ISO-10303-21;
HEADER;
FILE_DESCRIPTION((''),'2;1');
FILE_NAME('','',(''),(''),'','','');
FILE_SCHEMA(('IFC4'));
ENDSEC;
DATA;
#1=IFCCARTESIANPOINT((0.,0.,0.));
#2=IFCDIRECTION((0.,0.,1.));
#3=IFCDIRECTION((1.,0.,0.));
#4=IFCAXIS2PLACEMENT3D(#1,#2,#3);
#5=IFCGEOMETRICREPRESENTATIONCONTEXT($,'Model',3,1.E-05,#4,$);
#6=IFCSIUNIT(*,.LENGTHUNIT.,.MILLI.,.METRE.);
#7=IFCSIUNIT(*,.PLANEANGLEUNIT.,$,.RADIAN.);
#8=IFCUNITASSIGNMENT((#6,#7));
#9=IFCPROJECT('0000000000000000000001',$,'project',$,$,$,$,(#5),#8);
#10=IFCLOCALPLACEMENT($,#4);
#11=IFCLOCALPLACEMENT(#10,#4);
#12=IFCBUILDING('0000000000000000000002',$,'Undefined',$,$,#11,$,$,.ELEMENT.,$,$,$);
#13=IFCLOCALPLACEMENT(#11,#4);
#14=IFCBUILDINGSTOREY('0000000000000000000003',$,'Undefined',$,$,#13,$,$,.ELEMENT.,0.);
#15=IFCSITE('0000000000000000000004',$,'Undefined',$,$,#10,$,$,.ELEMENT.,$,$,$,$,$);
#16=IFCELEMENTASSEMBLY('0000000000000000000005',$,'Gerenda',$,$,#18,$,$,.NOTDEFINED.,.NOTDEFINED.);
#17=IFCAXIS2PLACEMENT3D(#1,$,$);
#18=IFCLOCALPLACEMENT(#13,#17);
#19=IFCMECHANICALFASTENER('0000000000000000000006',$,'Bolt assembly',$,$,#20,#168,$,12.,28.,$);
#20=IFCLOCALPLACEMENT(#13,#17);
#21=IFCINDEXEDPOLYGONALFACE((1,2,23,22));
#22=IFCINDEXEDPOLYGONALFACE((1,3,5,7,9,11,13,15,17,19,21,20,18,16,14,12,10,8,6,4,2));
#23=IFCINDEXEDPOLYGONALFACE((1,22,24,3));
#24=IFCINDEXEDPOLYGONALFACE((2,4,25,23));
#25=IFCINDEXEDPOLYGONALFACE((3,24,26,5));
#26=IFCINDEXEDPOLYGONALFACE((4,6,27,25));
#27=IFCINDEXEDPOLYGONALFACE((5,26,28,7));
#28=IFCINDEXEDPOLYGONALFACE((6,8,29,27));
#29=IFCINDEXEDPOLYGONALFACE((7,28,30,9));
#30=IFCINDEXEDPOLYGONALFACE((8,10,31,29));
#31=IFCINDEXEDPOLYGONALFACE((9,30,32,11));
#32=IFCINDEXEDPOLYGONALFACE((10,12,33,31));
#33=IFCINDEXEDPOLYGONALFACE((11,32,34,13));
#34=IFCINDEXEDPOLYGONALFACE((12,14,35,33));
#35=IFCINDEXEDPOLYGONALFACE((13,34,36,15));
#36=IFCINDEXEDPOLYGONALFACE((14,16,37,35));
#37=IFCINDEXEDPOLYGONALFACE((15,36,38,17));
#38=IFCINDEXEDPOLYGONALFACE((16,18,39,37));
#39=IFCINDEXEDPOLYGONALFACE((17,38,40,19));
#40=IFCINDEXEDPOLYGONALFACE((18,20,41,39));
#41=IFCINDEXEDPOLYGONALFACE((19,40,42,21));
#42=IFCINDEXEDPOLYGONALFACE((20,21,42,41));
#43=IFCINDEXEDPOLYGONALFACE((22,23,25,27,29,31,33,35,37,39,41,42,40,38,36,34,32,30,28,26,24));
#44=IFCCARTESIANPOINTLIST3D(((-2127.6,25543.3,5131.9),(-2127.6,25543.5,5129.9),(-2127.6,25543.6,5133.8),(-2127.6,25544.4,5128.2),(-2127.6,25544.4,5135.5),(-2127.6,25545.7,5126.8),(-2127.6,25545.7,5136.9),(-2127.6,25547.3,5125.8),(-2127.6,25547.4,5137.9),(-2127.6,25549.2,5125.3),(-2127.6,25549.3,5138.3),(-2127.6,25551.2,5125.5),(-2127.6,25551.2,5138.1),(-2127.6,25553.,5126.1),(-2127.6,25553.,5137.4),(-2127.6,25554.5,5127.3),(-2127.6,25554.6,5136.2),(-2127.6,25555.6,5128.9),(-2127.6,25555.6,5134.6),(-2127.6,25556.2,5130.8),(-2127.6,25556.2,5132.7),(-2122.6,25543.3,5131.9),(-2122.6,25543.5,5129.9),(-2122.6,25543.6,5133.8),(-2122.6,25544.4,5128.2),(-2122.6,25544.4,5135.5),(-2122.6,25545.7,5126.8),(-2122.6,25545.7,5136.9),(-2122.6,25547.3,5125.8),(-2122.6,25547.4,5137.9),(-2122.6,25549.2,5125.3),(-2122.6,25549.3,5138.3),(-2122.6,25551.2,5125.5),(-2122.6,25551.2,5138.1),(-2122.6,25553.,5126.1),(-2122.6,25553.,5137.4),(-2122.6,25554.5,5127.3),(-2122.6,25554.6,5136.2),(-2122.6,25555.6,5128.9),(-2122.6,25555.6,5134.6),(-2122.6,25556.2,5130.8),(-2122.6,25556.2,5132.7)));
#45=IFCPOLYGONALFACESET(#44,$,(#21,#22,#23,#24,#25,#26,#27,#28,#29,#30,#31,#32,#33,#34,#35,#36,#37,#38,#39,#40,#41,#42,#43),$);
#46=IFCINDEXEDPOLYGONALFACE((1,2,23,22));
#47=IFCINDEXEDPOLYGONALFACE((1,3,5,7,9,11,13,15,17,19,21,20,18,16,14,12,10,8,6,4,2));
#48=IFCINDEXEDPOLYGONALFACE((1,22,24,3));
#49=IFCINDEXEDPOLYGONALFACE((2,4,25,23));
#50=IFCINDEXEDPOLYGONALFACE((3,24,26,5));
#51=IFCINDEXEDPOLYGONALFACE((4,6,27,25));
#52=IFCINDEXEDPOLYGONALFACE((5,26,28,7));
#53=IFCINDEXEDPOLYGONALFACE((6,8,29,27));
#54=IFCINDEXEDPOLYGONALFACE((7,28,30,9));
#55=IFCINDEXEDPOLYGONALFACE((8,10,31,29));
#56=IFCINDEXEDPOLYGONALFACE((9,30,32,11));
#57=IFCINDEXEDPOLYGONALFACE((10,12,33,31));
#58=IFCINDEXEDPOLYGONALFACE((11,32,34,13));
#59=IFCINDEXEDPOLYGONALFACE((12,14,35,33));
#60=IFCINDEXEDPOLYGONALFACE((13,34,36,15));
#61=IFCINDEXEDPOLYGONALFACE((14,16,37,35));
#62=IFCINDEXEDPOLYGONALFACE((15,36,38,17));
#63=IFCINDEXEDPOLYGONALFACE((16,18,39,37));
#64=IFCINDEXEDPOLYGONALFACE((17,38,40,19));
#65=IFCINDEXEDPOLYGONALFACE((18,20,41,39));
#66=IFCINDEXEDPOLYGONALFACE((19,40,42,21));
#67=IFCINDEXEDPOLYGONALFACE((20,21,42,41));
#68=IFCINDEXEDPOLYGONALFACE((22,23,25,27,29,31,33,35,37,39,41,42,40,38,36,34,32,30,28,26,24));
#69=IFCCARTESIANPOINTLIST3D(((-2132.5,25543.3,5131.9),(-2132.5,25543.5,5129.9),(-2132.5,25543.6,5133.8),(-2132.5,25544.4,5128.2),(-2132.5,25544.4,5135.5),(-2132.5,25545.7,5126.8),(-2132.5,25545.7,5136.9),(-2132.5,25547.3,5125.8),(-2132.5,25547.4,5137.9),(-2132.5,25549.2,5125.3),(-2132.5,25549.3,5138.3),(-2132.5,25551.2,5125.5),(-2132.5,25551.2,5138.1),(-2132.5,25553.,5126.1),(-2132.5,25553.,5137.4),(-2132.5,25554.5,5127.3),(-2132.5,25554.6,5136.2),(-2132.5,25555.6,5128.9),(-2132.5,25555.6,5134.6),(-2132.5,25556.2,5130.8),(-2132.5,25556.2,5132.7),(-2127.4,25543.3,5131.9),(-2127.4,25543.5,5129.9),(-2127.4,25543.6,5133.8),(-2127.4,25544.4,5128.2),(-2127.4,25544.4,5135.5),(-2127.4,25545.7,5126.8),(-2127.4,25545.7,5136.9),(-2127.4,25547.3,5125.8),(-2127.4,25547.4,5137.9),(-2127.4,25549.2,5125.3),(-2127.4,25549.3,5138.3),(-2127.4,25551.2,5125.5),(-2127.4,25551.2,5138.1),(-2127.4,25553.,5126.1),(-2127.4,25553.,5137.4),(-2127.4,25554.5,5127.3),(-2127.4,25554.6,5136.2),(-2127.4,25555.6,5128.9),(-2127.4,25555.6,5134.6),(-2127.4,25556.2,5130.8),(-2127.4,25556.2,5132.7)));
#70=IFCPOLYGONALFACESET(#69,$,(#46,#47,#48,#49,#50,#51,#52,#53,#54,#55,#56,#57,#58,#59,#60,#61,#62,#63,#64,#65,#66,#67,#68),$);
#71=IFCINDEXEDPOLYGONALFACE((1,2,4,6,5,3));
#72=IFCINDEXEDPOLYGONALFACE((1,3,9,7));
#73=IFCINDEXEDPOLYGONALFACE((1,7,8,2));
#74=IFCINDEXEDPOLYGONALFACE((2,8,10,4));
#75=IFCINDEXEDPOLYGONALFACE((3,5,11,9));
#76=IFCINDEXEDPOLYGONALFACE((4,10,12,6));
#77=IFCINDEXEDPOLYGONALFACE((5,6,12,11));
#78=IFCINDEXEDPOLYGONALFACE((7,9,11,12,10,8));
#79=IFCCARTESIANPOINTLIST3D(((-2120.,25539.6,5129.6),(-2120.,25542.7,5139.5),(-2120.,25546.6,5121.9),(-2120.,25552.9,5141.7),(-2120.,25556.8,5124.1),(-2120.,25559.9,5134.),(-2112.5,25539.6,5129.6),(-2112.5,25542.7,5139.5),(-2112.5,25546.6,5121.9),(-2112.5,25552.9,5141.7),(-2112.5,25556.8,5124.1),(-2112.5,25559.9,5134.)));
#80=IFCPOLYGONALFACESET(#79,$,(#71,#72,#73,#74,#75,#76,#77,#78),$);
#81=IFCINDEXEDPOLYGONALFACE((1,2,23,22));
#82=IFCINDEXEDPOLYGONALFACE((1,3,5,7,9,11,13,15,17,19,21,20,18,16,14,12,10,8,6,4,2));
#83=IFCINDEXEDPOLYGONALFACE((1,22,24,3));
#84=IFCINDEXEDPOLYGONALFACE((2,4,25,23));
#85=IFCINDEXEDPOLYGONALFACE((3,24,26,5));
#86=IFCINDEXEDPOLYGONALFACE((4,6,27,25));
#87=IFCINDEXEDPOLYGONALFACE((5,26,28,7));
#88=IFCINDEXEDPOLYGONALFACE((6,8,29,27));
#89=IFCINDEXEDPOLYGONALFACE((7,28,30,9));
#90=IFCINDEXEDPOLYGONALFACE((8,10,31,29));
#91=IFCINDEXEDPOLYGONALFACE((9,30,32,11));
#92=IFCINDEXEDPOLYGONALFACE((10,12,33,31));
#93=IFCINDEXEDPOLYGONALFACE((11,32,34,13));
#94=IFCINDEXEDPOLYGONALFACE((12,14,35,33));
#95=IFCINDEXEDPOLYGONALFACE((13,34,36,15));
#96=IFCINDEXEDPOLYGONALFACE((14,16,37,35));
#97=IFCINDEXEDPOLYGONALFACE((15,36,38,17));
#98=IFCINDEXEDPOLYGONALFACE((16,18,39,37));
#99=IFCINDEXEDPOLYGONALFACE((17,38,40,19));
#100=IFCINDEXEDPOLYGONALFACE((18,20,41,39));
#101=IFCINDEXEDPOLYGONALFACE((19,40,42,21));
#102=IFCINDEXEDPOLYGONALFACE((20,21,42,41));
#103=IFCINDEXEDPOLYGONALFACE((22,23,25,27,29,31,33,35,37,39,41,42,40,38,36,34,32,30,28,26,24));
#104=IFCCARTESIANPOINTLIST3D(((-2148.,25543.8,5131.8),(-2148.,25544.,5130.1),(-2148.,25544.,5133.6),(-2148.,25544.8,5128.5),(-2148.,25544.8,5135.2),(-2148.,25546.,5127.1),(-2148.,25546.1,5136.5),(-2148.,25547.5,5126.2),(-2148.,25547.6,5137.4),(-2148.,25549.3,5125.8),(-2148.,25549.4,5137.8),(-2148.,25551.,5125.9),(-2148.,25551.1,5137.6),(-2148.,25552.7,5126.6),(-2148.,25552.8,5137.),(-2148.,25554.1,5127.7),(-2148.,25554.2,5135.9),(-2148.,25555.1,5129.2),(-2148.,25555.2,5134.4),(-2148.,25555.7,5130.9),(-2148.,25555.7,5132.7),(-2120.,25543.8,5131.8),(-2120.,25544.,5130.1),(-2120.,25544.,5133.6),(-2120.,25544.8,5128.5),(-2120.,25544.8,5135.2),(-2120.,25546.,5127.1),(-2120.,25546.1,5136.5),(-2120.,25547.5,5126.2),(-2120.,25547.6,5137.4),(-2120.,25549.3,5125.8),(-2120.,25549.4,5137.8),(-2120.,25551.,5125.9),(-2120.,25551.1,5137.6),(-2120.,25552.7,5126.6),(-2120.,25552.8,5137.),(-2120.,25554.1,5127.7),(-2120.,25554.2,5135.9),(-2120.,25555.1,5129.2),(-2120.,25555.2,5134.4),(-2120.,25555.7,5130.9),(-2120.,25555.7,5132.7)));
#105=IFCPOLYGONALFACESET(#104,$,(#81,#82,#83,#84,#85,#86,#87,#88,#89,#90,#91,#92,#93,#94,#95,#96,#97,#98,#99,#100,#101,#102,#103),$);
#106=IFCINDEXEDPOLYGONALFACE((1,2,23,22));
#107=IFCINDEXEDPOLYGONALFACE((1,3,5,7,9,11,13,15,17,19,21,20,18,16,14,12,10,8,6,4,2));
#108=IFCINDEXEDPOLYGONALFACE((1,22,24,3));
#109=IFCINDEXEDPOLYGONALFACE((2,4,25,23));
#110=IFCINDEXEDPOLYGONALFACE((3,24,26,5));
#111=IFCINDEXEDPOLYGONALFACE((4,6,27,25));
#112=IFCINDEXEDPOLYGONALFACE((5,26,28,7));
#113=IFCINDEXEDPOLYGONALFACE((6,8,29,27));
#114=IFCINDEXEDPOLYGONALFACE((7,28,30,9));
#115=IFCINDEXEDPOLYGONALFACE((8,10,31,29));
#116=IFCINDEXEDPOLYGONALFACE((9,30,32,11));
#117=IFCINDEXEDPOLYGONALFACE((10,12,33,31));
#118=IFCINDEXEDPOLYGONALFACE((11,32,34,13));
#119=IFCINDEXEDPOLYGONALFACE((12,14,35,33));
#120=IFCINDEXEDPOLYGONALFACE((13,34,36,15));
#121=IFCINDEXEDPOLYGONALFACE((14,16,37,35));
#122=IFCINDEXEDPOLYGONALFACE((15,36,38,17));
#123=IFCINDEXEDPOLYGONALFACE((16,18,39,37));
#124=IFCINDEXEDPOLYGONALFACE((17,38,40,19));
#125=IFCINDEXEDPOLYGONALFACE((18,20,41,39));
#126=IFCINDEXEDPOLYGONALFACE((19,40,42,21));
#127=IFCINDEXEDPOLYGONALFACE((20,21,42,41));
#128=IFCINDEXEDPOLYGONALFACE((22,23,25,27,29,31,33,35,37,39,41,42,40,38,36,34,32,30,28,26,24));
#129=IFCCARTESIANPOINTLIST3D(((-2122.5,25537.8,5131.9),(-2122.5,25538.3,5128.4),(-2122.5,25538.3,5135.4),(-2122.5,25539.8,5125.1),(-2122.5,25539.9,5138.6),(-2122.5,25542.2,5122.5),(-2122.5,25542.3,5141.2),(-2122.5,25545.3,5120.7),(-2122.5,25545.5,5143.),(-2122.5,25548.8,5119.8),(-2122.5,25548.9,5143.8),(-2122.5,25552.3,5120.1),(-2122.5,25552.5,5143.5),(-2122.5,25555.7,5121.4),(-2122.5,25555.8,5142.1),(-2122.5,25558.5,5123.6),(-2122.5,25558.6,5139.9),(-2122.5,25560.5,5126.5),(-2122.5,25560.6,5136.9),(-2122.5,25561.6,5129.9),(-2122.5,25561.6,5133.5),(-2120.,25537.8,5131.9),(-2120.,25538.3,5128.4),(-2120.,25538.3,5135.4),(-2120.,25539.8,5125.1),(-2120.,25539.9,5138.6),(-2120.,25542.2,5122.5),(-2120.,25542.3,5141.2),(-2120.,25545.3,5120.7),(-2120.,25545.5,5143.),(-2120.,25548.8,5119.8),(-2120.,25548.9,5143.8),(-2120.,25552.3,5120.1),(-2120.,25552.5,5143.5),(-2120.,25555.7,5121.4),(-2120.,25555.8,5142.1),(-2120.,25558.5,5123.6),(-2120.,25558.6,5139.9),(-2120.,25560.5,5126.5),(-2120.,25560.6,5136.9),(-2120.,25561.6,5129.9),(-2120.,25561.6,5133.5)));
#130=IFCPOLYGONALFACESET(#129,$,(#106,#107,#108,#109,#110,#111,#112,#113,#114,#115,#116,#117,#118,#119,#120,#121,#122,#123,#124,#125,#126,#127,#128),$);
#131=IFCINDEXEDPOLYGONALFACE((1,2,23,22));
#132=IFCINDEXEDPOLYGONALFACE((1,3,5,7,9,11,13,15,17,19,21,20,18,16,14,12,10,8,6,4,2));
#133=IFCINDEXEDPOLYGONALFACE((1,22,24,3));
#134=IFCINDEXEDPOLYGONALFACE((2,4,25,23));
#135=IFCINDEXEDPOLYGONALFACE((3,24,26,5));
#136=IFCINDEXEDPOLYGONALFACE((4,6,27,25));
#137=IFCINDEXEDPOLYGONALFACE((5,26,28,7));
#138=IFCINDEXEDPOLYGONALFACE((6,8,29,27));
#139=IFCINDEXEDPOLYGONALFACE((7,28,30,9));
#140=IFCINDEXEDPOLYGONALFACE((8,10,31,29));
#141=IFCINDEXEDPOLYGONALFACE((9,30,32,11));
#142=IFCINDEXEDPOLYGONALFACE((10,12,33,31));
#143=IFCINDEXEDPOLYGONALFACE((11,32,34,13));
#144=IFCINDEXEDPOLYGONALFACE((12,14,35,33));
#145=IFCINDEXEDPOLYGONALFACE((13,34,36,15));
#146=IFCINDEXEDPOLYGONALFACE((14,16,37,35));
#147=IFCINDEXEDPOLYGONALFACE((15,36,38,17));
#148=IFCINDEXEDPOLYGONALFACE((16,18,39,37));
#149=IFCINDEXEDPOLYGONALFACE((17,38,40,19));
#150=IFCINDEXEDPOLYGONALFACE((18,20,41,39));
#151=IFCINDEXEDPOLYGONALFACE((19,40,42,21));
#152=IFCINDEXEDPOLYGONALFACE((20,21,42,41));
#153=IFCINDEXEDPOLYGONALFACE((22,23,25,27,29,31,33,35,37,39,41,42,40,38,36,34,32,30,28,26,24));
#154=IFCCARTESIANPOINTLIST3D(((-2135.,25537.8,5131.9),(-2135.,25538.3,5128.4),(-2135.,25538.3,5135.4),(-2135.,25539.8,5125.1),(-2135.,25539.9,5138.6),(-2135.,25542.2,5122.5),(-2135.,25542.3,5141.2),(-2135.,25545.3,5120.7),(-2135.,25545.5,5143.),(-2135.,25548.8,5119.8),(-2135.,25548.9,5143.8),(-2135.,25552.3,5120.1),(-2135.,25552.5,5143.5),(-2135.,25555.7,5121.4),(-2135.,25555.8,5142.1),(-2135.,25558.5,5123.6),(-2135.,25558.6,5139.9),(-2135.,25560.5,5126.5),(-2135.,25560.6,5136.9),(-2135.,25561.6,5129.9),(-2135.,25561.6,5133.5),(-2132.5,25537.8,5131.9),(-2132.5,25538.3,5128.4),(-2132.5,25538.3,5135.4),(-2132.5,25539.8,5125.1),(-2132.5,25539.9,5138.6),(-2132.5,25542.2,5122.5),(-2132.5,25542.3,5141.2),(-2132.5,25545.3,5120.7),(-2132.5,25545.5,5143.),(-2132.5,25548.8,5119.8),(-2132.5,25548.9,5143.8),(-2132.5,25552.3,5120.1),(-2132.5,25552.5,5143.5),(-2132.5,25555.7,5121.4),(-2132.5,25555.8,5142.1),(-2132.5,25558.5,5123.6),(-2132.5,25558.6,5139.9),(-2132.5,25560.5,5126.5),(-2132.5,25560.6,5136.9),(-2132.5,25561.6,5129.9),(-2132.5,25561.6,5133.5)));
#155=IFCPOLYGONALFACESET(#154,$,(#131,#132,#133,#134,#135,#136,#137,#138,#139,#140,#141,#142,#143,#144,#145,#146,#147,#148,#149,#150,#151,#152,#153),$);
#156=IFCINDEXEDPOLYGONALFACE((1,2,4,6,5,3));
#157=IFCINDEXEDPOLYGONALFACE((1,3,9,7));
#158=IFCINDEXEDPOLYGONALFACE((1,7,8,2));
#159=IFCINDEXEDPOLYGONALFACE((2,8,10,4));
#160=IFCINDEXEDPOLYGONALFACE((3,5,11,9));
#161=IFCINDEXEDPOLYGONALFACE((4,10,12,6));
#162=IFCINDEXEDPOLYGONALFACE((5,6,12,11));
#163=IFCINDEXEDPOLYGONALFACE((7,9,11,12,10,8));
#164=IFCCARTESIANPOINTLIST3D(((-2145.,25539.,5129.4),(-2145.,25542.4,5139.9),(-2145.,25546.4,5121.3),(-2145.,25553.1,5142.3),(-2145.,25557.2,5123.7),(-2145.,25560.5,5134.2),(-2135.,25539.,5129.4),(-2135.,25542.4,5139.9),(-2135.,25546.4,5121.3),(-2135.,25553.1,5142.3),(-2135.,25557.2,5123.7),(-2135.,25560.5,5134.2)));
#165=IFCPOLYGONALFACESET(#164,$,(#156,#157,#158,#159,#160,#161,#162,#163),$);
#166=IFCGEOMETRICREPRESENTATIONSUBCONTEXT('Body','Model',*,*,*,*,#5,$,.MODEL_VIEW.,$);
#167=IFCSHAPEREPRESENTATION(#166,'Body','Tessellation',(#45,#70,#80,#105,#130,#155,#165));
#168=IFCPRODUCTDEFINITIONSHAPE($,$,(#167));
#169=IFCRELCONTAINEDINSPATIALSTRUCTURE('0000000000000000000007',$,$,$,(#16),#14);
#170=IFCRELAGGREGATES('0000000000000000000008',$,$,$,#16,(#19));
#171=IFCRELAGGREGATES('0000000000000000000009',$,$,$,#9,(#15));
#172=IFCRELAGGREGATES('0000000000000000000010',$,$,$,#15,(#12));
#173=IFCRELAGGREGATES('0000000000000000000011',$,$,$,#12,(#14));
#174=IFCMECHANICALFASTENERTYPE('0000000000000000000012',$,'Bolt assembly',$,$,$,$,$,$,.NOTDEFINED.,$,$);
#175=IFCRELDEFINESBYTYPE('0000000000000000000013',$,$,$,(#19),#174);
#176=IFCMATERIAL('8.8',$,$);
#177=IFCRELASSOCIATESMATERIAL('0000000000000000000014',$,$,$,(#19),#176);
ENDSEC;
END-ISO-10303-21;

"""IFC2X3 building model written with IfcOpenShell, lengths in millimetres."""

from ifc_helpers import new_model, si_unit, frame, origin_with_axes, origin_2d_with_axis, place, context, subcontext, project, spatial, polyline, circle, outline, extrude, source, transform, mapped, material, type_object, element, aggregate, save


model = new_model("IFC2X3")

# Units and contexts
model_context = context("Model", 3, precision=1e-05, world=origin_with_axes())
body_context = subcontext(model_context, "Body", "Model", "MODEL_VIEW")
ifc_project = project(units=[si_unit("LENGTHUNIT", "METRE", prefix="MILLI"), si_unit("PLANEANGLEUNIT", "RADIAN")], contexts=[model_context])

# Site, building, storey
site_placement = place(None, origin_with_axes())
site = spatial("IfcSite", under=ifc_project, at=site_placement, Name="Undefined", CompositionType="ELEMENT")
building_placement = place(site_placement, origin_with_axes())
building = spatial("IfcBuilding", under=site, at=building_placement, Name="Undefined", CompositionType="ELEMENT")
storey_placement = place(building_placement, origin_with_axes())
storey = spatial("IfcBuildingStorey", under=building, at=storey_placement, Name="Undefined", CompositionType="ELEMENT", Elevation=0.0)

# Element assembly
assembly_1_placement = place(storey_placement, origin_with_axes())
assembly_1 = element("IfcElementAssembly", 1, at=assembly_1_placement, inside=storey, Name="Gerenda", AssemblyPlace="NOTDEFINED", PredefinedType="NOTDEFINED")

# Mechanical fastener
ifc_material_1 = material(Name="8.8")
mechanical_fastener_type = type_object("IfcMechanicalFastenerType", Name="Bolt assembly")
shared_shape_1 = source(origin_with_axes(), body_context, "Body", "SweptSolid", [
    extrude(circle(Radius=6.5, at=origin_2d_with_axis()), frame((0.0, -7.4, 0.0), z_axis=(0.0, 1.0, 0.0), x_axis=(1.0, 0.0, 0.0)), (0.0, 0.0, 1.0), 5.0),
    extrude(circle(Radius=6.5, at=origin_2d_with_axis()), frame((0.0, -2.6, 0.0), z_axis=(0.0, 1.0, 0.0), x_axis=(1.0, 0.0, 0.0)), (0.0, 0.0, 1.0), 5.1),
    extrude(outline(polyline([(9.0, -5.2), (9.0, 5.2), (0.0, 10.4), (-9.0, 5.2), (-9.0, -5.2), (0.0, -10.4), (9.0, -5.2)])), frame((0.0, -17.5, 0.0), z_axis=(0.0, 1.0, 0.0), x_axis=(1.0, 0.0, 0.0)), (0.0, 0.0, 1.0), 7.5),
    extrude(circle(Radius=6.0, at=origin_2d_with_axis()), frame((0.0, -10.0, 0.0), z_axis=(0.0, 1.0, 0.0), x_axis=(1.0, 0.0, 0.0)), (0.0, 0.0, 1.0), 28.0),
    extrude(circle(Radius=12.0, at=origin_2d_with_axis()), frame((0.0, -10.0, 0.0), z_axis=(0.0, 1.0, 0.0), x_axis=(1.0, 0.0, 0.0)), (0.0, 0.0, 1.0), 2.5),
    extrude(circle(Radius=12.0, at=origin_2d_with_axis()), frame((0.0, 2.5, 0.0), z_axis=(0.0, 1.0, 0.0), x_axis=(1.0, 0.0, 0.0)), (0.0, 0.0, 1.0), 2.5),
    extrude(outline(polyline([(9.5, -5.5), (9.5, 5.5), (0.0, 11.0), (-9.5, 5.5), (-9.5, -5.5), (0.0, -11.0), (9.5, -5.5)])), frame((0.0, 5.0, 0.0), z_axis=(0.0, 1.0, 0.0), x_axis=(1.0, 0.0, 0.0)), (0.0, 0.0, 1.0), 10.0),
])
mechanical_fastener_1_placement = place(assembly_1_placement, frame((-2130.0, 25549.8, 5131.8), z_axis=(-0.000003, -0.674627, 0.738159), x_axis=(0.000003, 0.738159, 0.674627)))
mechanical_fastener_1 = element("IfcMechanicalFastener", 2, at=mechanical_fastener_1_placement, type_object=mechanical_fastener_type, material=ifc_material_1, Name="Bolt assembly", NominalDiameter=12.0, NominalLength=28.0, context=body_context, shape_type="MappedRepresentation", body=[
    mapped(shared_shape_1, transform((0.0, 0.0, 0.0))),
])
aggregate(assembly_1, [mechanical_fastener_1])

save(model, "model.ifc")
